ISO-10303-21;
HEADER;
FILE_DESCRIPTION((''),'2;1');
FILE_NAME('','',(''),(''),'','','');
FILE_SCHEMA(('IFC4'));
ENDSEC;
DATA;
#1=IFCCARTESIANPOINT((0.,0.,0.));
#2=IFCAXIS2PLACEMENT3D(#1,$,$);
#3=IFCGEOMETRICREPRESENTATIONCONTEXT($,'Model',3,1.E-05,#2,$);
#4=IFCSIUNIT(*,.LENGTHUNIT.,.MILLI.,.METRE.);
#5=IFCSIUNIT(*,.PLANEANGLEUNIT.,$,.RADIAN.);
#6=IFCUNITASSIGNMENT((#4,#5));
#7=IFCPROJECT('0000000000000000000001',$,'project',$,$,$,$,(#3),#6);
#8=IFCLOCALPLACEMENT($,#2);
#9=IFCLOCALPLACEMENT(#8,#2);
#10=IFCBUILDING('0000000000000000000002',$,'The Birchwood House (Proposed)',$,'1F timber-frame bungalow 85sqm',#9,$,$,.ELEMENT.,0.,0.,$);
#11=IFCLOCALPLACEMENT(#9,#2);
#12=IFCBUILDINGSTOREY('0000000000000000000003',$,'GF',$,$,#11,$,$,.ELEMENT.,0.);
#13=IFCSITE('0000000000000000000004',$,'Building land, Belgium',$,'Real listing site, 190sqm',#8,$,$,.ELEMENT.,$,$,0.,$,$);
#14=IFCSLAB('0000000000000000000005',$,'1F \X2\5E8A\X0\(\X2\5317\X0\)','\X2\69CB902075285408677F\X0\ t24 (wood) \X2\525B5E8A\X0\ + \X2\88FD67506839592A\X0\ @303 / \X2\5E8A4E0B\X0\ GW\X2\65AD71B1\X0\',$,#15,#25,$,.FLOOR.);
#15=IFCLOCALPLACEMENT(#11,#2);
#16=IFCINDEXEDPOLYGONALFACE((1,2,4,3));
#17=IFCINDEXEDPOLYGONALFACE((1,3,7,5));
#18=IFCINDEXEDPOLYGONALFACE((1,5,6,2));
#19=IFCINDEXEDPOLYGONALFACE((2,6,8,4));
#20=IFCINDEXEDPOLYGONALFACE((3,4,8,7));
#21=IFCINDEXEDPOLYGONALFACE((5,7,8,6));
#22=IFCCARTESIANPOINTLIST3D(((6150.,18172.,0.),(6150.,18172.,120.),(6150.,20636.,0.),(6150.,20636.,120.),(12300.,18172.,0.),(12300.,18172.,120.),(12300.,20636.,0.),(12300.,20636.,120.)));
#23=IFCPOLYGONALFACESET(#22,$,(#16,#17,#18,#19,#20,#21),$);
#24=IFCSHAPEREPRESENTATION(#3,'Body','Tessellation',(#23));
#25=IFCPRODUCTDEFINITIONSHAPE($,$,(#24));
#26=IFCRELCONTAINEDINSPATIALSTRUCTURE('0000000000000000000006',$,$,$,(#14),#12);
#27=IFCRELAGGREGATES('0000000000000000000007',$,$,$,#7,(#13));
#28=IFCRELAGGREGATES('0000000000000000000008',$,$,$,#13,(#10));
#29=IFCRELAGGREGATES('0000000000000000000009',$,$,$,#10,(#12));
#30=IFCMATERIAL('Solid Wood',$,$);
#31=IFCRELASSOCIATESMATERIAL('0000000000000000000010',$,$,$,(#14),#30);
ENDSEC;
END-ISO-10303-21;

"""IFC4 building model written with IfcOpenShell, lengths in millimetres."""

from ifc_helpers import new_model, si_unit, frame, frame_2d, origin, place, context, project, spatial, rectangle, extrude, material, element, save


model = new_model("IFC4")

# Units and contexts
model_context = context("Model", 3, precision=1e-05, world=origin())
ifc_project = project(units=[si_unit("LENGTHUNIT", "METRE", prefix="MILLI"), si_unit("PLANEANGLEUNIT", "RADIAN")], contexts=[model_context])

# Site, building, storey
site_placement = place(None, origin())
site = spatial("IfcSite", under=ifc_project, at=site_placement, Name="Building land, Belgium", ObjectType="Real listing site, 190sqm", CompositionType="ELEMENT", RefElevation=0.0)
building_placement = place(site_placement, origin())
building = spatial("IfcBuilding", under=site, at=building_placement, Name="The Birchwood House (Proposed)", ObjectType="1F timber-frame bungalow 85sqm", CompositionType="ELEMENT", ElevationOfRefHeight=0.0, ElevationOfTerrain=0.0)
storey_placement = place(building_placement, origin())
storey = spatial("IfcBuildingStorey", under=building, at=storey_placement, Name="GF", CompositionType="ELEMENT", Elevation=0.0)

# Slab
ifc_material_1 = material(Name="Solid Wood")
slab_1_placement = place(storey_placement, frame((3075.0, 9086.0, 0.0)))
element("IfcSlab", 1, at=slab_1_placement, inside=storey, material=ifc_material_1, Name="1F 床(北)", Description="構造用合板 t24 (wood) 剛床 + 製材根太 @303 / 床下 GW断熱", PredefinedType="FLOOR", context=model_context, shape_type="SweptSolid", body=[
    extrude(rectangle(XDim=6150.0, YDim=2464.0, at=frame_2d((3075.0, 1232.0))), frame((3075.0, 9086.0, 0.0)), (0.0, 0.0, 1.0), 120.0),
])

save(model, "model.ifc")
